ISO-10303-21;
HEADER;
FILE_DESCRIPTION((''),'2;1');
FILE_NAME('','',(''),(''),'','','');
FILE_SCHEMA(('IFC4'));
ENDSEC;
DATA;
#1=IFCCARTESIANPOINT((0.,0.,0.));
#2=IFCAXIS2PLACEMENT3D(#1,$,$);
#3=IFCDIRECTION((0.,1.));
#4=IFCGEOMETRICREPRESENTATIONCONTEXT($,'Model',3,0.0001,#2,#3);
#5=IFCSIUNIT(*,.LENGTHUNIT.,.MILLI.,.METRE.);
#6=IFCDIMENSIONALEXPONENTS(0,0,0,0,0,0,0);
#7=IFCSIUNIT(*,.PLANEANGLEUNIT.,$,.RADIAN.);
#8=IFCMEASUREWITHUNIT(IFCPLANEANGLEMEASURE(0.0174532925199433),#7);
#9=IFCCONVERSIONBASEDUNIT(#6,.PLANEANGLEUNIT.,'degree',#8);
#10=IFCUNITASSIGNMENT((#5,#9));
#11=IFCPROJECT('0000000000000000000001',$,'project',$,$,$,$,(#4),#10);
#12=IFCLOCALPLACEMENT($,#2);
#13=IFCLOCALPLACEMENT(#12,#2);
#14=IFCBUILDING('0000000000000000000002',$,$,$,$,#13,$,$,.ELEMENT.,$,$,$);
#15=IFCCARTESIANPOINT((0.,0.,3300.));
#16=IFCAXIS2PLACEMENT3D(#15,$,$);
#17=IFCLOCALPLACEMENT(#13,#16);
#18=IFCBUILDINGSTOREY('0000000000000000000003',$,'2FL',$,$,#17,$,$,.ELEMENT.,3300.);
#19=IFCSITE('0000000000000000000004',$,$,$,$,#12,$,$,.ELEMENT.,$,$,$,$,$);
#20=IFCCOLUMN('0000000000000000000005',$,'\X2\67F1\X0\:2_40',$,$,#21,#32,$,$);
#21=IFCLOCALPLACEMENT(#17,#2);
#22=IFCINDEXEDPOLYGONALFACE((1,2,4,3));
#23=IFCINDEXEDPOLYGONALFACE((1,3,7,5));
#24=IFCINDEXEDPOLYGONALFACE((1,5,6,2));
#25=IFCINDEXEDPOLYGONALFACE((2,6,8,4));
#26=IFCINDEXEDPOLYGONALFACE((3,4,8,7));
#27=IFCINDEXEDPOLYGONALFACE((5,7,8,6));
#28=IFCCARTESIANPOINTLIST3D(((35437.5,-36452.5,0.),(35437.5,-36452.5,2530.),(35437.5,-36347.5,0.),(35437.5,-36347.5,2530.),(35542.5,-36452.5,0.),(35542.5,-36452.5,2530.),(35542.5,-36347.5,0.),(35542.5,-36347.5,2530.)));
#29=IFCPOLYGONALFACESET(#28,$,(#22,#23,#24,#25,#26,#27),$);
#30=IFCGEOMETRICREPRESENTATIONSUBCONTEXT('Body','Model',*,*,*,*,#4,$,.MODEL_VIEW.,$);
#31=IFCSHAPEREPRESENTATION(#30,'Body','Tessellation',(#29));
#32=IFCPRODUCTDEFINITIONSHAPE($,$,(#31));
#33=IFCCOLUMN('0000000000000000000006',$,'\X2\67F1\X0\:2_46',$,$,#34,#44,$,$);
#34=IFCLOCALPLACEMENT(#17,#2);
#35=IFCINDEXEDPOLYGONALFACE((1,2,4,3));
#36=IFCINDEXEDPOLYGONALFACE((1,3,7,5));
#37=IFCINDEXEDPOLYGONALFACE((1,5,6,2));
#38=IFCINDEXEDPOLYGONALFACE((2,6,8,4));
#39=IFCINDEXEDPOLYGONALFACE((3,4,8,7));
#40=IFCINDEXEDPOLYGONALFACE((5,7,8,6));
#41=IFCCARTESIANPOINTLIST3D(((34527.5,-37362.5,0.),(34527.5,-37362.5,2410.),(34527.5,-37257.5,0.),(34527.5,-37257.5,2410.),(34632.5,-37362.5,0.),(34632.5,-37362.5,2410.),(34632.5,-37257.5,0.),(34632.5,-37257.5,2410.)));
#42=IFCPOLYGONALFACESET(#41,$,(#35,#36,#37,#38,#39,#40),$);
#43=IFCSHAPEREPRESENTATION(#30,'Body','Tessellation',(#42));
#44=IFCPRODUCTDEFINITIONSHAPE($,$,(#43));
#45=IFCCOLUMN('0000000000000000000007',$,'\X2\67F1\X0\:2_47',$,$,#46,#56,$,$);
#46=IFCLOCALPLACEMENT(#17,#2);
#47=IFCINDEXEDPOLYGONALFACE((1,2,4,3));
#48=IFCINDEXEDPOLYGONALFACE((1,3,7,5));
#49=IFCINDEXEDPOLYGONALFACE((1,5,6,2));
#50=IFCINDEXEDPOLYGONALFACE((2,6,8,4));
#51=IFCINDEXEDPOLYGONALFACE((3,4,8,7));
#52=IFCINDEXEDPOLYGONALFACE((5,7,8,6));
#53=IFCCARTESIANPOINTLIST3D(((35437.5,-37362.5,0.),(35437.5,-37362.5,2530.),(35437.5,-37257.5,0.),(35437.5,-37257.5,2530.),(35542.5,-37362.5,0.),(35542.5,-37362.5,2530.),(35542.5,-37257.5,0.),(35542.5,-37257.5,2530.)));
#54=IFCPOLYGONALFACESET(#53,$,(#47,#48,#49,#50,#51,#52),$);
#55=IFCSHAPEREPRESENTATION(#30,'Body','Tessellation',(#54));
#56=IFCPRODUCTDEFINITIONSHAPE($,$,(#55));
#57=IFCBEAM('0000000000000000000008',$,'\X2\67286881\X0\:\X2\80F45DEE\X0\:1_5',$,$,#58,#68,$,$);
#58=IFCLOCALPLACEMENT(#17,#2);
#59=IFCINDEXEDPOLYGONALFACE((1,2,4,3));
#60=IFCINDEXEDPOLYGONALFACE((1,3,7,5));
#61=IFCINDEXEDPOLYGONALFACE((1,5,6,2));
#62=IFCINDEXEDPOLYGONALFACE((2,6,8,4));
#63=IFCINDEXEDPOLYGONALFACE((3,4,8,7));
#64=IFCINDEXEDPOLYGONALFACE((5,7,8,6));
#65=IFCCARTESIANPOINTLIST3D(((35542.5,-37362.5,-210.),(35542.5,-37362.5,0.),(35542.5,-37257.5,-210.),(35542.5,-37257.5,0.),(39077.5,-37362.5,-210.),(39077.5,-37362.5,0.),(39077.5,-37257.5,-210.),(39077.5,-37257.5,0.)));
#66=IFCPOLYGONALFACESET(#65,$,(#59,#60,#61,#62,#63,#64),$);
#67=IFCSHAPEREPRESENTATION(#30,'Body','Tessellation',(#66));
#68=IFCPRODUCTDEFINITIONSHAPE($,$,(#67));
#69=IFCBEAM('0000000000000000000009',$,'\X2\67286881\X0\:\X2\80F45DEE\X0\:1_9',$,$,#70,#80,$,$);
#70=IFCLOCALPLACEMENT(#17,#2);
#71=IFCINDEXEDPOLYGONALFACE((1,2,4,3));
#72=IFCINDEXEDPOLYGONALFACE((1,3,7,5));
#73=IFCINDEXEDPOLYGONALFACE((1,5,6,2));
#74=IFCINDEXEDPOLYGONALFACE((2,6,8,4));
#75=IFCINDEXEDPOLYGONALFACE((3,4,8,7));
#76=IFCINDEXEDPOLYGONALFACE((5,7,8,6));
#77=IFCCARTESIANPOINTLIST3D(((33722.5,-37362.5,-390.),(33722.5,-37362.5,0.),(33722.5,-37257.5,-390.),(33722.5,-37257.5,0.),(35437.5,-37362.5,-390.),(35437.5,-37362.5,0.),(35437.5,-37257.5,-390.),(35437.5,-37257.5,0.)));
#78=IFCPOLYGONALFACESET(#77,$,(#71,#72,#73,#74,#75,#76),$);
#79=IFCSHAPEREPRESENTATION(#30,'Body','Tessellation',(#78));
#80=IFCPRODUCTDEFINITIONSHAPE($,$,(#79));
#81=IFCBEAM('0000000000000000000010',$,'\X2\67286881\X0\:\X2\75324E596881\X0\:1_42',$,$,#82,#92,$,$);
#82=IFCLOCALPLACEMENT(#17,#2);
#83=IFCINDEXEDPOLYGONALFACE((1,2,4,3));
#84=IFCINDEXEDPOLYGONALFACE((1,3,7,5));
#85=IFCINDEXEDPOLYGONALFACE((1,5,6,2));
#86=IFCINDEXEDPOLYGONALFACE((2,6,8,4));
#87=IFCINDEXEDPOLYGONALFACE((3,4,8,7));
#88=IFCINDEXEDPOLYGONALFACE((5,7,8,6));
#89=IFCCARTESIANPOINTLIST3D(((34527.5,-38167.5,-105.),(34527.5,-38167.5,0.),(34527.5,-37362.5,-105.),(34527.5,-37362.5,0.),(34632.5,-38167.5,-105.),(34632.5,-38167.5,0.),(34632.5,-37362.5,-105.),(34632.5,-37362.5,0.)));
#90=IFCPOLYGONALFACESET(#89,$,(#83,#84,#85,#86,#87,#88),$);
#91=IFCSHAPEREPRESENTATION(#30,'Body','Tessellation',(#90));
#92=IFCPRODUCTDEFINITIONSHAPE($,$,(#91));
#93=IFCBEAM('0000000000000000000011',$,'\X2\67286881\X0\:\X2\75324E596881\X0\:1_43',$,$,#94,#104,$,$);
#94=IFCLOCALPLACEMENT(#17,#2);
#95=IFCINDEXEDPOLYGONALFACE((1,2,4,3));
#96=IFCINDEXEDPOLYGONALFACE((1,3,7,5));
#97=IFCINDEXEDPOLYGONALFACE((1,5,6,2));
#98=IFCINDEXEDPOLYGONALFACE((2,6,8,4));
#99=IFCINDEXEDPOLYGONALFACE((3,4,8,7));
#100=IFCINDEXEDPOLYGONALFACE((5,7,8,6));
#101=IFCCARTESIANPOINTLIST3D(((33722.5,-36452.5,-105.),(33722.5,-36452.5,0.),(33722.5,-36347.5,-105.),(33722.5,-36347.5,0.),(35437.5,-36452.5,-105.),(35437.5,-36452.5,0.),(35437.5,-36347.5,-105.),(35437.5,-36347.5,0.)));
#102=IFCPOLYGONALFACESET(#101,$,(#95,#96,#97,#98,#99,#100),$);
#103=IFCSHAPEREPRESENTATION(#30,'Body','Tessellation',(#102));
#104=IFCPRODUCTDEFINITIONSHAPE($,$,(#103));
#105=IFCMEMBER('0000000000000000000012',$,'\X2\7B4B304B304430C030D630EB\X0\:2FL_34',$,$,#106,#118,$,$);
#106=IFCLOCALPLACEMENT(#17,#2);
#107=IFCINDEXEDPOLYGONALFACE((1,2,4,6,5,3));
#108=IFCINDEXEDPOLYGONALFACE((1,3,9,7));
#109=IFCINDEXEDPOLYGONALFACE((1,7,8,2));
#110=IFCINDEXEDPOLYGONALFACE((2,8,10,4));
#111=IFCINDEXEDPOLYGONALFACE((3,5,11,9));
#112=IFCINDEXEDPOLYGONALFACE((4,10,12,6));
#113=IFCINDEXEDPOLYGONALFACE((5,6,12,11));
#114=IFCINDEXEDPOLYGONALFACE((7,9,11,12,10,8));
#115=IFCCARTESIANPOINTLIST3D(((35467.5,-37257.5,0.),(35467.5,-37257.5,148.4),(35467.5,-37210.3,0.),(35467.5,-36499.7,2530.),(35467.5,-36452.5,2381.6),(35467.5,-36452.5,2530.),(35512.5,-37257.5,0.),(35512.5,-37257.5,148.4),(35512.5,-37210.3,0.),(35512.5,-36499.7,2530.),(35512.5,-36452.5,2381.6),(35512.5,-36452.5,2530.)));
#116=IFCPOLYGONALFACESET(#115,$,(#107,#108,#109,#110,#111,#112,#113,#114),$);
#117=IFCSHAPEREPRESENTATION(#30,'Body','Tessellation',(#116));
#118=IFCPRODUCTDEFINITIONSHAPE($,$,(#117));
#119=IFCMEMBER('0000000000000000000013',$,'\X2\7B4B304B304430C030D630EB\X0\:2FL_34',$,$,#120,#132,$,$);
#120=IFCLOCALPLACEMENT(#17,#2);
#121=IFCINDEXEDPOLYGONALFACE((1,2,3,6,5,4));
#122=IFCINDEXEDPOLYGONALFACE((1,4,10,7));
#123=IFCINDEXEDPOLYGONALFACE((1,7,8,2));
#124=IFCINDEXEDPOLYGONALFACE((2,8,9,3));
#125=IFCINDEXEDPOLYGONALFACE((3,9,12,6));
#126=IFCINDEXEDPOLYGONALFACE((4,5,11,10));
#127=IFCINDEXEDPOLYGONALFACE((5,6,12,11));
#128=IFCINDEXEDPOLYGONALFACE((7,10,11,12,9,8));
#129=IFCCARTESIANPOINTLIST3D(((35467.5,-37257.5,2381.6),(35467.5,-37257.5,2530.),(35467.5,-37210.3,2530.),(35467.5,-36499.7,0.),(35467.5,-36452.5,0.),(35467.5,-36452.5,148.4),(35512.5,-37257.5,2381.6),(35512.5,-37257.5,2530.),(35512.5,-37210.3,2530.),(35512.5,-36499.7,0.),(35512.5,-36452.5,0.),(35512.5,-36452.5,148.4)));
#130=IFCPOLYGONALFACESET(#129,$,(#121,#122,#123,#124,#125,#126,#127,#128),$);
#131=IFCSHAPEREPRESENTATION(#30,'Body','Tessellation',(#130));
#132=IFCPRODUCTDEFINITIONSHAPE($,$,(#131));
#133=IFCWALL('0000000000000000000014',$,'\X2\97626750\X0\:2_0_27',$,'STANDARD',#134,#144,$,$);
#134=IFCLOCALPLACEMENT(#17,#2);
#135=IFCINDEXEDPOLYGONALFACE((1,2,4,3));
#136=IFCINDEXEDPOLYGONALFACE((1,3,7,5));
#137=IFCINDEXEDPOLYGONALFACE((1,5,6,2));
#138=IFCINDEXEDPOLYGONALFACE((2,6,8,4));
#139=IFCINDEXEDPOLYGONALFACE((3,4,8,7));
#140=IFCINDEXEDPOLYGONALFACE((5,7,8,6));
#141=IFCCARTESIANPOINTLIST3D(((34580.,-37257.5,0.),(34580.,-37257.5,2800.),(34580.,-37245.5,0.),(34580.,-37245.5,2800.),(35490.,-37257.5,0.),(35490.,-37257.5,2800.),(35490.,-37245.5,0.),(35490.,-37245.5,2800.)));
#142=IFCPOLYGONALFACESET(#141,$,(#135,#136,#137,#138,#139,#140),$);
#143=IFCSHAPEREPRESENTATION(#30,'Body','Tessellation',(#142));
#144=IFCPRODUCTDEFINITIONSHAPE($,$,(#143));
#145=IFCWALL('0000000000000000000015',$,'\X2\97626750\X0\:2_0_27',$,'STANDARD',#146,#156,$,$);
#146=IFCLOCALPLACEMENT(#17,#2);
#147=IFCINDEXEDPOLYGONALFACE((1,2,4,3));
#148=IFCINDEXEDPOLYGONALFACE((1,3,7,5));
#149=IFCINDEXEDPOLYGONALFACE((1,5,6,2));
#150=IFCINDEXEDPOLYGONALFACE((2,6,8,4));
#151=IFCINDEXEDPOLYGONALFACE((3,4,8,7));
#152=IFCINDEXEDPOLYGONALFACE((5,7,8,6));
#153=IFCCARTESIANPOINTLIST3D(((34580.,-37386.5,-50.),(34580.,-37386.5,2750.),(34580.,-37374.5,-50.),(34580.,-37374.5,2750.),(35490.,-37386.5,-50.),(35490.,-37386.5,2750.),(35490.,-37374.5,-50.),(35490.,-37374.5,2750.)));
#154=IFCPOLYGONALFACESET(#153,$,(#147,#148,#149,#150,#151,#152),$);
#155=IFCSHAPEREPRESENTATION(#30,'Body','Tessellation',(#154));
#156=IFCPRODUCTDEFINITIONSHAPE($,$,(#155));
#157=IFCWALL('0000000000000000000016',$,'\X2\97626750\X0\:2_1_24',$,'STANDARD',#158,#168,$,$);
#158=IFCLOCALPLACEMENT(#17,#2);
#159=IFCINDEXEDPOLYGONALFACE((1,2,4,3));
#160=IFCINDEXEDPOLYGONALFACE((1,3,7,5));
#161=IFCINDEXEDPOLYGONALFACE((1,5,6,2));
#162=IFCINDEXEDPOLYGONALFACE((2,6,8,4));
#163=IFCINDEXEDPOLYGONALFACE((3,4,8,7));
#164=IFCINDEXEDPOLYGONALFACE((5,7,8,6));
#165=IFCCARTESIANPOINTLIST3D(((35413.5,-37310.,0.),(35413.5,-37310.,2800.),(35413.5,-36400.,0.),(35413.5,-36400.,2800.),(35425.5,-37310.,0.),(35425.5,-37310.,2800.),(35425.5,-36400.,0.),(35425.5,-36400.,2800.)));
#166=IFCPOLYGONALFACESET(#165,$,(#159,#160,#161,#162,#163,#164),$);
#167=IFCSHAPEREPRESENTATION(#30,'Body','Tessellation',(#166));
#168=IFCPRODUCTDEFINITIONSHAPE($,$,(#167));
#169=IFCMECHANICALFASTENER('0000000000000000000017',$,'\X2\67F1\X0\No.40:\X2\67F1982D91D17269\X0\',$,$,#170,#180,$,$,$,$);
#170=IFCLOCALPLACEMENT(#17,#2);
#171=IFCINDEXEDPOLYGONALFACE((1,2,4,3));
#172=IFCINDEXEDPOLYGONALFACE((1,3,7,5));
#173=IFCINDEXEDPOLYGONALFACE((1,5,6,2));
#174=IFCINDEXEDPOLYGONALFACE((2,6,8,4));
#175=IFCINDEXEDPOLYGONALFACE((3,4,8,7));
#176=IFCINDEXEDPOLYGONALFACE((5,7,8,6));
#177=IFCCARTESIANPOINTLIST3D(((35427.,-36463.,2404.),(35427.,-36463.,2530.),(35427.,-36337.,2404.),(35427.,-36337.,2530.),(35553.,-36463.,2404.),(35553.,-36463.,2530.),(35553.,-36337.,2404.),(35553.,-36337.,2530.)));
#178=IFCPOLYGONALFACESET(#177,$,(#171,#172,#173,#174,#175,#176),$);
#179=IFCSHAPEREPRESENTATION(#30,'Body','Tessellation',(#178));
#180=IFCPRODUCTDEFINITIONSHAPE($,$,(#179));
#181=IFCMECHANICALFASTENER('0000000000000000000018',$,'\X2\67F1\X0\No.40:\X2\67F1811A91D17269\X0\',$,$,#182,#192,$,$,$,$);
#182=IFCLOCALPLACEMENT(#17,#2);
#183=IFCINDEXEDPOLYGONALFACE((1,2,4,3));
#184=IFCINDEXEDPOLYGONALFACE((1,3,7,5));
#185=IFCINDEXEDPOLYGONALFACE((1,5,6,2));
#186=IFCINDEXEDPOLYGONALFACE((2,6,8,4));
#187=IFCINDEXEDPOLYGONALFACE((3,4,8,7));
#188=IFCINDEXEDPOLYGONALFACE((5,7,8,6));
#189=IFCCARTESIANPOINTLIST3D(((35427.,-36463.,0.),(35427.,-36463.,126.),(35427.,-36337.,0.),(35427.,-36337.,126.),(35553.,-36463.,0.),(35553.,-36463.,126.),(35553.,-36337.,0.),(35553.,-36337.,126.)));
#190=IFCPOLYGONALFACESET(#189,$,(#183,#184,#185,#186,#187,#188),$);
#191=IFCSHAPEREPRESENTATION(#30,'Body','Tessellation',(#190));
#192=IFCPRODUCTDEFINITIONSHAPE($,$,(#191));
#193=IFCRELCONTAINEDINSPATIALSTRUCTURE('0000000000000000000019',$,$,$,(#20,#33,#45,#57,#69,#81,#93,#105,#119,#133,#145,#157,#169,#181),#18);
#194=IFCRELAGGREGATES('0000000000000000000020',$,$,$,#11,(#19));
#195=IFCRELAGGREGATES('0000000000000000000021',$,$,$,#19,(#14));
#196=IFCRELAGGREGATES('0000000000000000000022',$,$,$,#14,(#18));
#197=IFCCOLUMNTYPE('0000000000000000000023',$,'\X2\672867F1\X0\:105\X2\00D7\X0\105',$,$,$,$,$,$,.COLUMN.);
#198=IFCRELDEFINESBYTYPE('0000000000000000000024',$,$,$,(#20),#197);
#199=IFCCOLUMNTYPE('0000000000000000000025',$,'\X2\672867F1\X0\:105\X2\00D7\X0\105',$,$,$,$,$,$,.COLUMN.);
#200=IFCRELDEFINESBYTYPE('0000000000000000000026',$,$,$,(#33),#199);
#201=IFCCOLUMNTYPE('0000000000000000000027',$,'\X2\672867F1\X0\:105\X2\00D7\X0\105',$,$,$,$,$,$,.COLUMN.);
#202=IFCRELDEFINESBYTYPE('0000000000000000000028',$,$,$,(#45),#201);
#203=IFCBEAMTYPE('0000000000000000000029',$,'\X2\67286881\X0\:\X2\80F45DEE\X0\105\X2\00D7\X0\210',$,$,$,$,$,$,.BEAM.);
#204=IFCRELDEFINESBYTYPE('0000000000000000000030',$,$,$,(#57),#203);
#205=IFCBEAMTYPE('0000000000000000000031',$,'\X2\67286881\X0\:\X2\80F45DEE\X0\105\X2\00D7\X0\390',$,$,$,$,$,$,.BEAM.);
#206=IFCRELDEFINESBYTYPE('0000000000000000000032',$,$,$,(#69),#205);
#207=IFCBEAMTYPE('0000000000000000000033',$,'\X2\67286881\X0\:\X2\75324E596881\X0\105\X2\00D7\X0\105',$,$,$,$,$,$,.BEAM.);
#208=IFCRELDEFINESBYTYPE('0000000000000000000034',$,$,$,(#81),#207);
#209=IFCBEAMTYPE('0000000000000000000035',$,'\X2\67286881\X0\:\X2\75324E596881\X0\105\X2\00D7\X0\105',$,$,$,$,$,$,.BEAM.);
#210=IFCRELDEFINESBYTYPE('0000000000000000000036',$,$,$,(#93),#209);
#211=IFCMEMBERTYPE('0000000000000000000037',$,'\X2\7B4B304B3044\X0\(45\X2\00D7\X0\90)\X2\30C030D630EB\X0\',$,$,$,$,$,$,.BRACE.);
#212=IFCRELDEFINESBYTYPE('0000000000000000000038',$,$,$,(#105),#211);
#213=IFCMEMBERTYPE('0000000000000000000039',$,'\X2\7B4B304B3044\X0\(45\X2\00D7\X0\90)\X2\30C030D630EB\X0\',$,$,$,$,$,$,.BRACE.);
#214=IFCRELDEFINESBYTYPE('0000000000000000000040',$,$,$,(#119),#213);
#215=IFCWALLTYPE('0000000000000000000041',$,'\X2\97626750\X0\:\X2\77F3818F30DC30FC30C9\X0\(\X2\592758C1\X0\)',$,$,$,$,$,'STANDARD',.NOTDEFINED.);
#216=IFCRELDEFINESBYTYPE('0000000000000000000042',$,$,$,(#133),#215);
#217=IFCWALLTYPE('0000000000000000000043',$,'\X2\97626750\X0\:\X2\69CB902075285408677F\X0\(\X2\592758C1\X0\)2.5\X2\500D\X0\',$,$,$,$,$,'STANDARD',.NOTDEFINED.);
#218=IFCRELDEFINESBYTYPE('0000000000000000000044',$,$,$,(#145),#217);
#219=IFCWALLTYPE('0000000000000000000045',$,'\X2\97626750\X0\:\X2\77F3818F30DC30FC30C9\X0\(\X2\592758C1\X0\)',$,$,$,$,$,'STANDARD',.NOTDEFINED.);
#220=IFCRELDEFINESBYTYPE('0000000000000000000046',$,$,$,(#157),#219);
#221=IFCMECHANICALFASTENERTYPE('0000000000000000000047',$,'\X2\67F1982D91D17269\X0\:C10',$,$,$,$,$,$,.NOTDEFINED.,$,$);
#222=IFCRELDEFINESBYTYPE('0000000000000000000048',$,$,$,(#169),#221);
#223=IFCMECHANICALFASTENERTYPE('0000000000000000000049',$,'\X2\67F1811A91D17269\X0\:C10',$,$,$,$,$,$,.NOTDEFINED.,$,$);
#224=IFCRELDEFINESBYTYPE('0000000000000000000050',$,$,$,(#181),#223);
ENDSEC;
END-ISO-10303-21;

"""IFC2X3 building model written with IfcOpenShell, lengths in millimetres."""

from ifc_helpers import new_model, entity, si_unit, converted_unit, direction, frame, origin, origin_with_axes, origin_2d, place, context, subcontext, project, spatial, polyline, rectangle, outline, extrude, type_object, element, save


model = new_model("IFC2X3")

# Units and contexts
model_context = context("Model", 3, precision=0.0001, world=origin(), true_north=direction((0.0, 1.0)))
body_context = subcontext(model_context, "Body", "Model", "MODEL_VIEW")
ifc_project = project(units=[si_unit("LENGTHUNIT", "METRE", prefix="MILLI"), converted_unit("PLANEANGLEUNIT", "degree", entity("IfcPlaneAngleMeasure", 0.0174532925199433), si_unit("PLANEANGLEUNIT", "RADIAN"), dimensions=[0, 0, 0, 0, 0, 0, 0])], contexts=[model_context])

# Site, building, storey
site_placement = place(None, origin())
site = spatial("IfcSite", under=ifc_project, at=site_placement, CompositionType="ELEMENT")
building_placement = place(site_placement, origin())
building = spatial("IfcBuilding", under=site, at=building_placement, CompositionType="ELEMENT")
storey_placement = place(building_placement, frame((0.0, 0.0, 3300.0)))
storey = spatial("IfcBuildingStorey", under=building, at=storey_placement, Name="2FL", CompositionType="ELEMENT", Elevation=3300.0)

# Columns
column_type_1 = type_object("IfcColumnType", Name="木柱:105×105", PredefinedType="COLUMN")
column_1_placement = place(storey_placement, frame((35490.0, -36400.0, 0.0)))
element("IfcColumn", 1, at=column_1_placement, inside=storey, type_object=column_type_1, Name="柱:2_40", context=body_context, shape_type="SweptSolid", body=[
    extrude(rectangle(XDim=105.0, YDim=105.0, at=origin_2d()), origin_with_axes(), (0.0, 0.0, 1.0), 2530.0),
])
column_type_2 = type_object("IfcColumnType", Name="木柱:105×105", PredefinedType="COLUMN")
column_2_placement = place(storey_placement, frame((34580.0, -37310.0, 0.0)))
element("IfcColumn", 2, at=column_2_placement, inside=storey, type_object=column_type_2, Name="柱:2_46", context=body_context, shape_type="SweptSolid", body=[
    extrude(rectangle(XDim=105.0, YDim=105.0, at=origin_2d()), origin_with_axes(), (0.0, 0.0, 1.0), 2410.0),
])
column_type_3 = type_object("IfcColumnType", Name="木柱:105×105", PredefinedType="COLUMN")
column_3_placement = place(storey_placement, frame((35490.0, -37310.0, 0.0)))
element("IfcColumn", 3, at=column_3_placement, inside=storey, type_object=column_type_3, Name="柱:2_47", context=body_context, shape_type="SweptSolid", body=[
    extrude(rectangle(XDim=105.0, YDim=105.0, at=origin_2d()), origin_with_axes(), (0.0, 0.0, 1.0), 2530.0),
])

# Beams
beam_type_1 = type_object("IfcBeamType", Name="木梁:胴差105×210", PredefinedType="BEAM")
beam_1_placement = place(storey_placement, frame((35542.5, -37310.0, -105.0), z_axis=(1.0, 0.0, 0.0), x_axis=(0.0, 1.0, 0.0)))
element("IfcBeam", 4, at=beam_1_placement, inside=storey, type_object=beam_type_1, Name="木梁:胴差:1_5", context=body_context, shape_type="SweptSolid", body=[
    extrude(rectangle(XDim=105.0, YDim=210.0, at=origin_2d()), origin_with_axes(), (0.0, 0.0, 1.0), 3535.0),
])
beam_type_2 = type_object("IfcBeamType", Name="木梁:胴差105×390", PredefinedType="BEAM")
beam_2_placement = place(storey_placement, frame((33722.5, -37310.0, -195.0), z_axis=(1.0, 0.0, 0.0), x_axis=(0.0, 1.0, 0.0)))
element("IfcBeam", 5, at=beam_2_placement, inside=storey, type_object=beam_type_2, Name="木梁:胴差:1_9", context=body_context, shape_type="SweptSolid", body=[
    extrude(rectangle(XDim=105.0, YDim=390.0, at=origin_2d()), origin_with_axes(), (0.0, 0.0, 1.0), 1715.0),
])
beam_type_3 = type_object("IfcBeamType", Name="木梁:甲乙梁105×105", PredefinedType="BEAM")
beam_3_placement = place(storey_placement, frame((34580.0, -37362.5, -52.5), z_axis=(0.0, -1.0, 0.0), x_axis=(1.0, 0.0, 0.0)))
element("IfcBeam", 6, at=beam_3_placement, inside=storey, type_object=beam_type_3, Name="木梁:甲乙梁:1_42", context=body_context, shape_type="SweptSolid", body=[
    extrude(rectangle(XDim=105.0, YDim=105.0, at=origin_2d()), origin_with_axes(), (0.0, 0.0, 1.0), 805.0),
])
beam_type_4 = type_object("IfcBeamType", Name="木梁:甲乙梁105×105", PredefinedType="BEAM")
beam_4_placement = place(storey_placement, frame((33722.5, -36400.0, -52.5), z_axis=(1.0, 0.0, 0.0), x_axis=(0.0, 1.0, 0.0)))
element("IfcBeam", 7, at=beam_4_placement, inside=storey, type_object=beam_type_4, Name="木梁:甲乙梁:1_43", context=body_context, shape_type="SweptSolid", body=[
    extrude(rectangle(XDim=105.0, YDim=105.0, at=origin_2d()), origin_with_axes(), (0.0, 0.0, 1.0), 1715.0),
])

# Members
member_type_1 = type_object("IfcMemberType", Name="筋かい(45×90)ダブル", PredefinedType="BRACE")
member_1_placement = place(storey_placement, frame((35490.0, -37257.5, 0.0), z_axis=(0.0, 0.303204, 0.952926), x_axis=(0.0, -0.952926, 0.303204)))
element("IfcMember", 8, at=member_1_placement, inside=storey, type_object=member_type_1, Name="筋かいダブル:2FL_34", context=body_context, shape_type="SweptSolid", body=[
    extrude(outline(polyline([(0.0, 0.0), (14.3, -45.0), (2513.6, -45.0), (2655.0, 0.0), (2640.7, 45.0), (141.4, 45.0), (0.0, 0.0)])), frame((0.0, -22.5, 0.0), z_axis=(0.0, 1.0, 0.0), x_axis=(0.0, 0.0, 1.0)), (0.0, 0.0, 1.0), 45.0),
])
member_type_2 = type_object("IfcMemberType", Name="筋かい(45×90)ダブル", PredefinedType="BRACE")
member_2_placement = place(storey_placement, frame((35490.0, -36452.5, 0.0), z_axis=(0.0, -0.303204, 0.952926), x_axis=(0.0, 0.952926, 0.303204)))
element("IfcMember", 9, at=member_2_placement, inside=storey, type_object=member_type_2, Name="筋かいダブル:2FL_34", context=body_context, shape_type="SweptSolid", body=[
    extrude(outline(polyline([(0.0, 0.0), (14.3, -45.0), (2513.6, -45.0), (2655.0, 0.0), (2640.7, 45.0), (141.4, 45.0), (0.0, 0.0)])), frame((0.0, -22.5, 0.0), z_axis=(0.0, 1.0, 0.0), x_axis=(0.0, 0.0, 1.0)), (0.0, 0.0, 1.0), 45.0),
])

# Walls
wall_type_1 = type_object("IfcWallType", Name="面材:石膏ボード(大壁)", ElementType="STANDARD", PredefinedType="NOTDEFINED")
wall_1_placement = place(storey_placement, frame((35035.0, -37245.5, 0.0), z_axis=(0.0, -1.0, 0.0), x_axis=(1.0, 0.0, 0.0)))
element("IfcWall", 10, at=wall_1_placement, inside=storey, type_object=wall_type_1, Name="面材:2_0_27", ObjectType="STANDARD", context=body_context, shape_type="SweptSolid", body=[
    extrude(outline(polyline([(455.0, 0.0, 0.0), (-455.0, 0.0, 0.0), (-455.0, 2800.0, 0.0), (455.0, 2800.0, 0.0), (455.0, 0.0, 0.0)])), origin_with_axes(), (0.0, 0.0, 1.0), 12.0),
])
wall_type_2 = type_object("IfcWallType", Name="面材:構造用合板(大壁)2.5倍", ElementType="STANDARD", PredefinedType="NOTDEFINED")
wall_2_placement = place(storey_placement, frame((35035.0, -37374.5, -50.0), z_axis=(0.0, -1.0, 0.0), x_axis=(1.0, 0.0, 0.0)))
element("IfcWall", 11, at=wall_2_placement, inside=storey, type_object=wall_type_2, Name="面材:2_0_27", ObjectType="STANDARD", context=body_context, shape_type="SweptSolid", body=[
    extrude(outline(polyline([(455.0, 0.0, 0.0), (-455.0, 0.0, 0.0), (-455.0, 2800.0, 0.0), (455.0, 2800.0, 0.0), (455.0, 0.0, 0.0)])), origin_with_axes(), (0.0, 0.0, 1.0), 12.0),
])
wall_type_3 = type_object("IfcWallType", Name="面材:石膏ボード(大壁)", ElementType="STANDARD", PredefinedType="NOTDEFINED")
wall_3_placement = place(storey_placement, frame((35425.5, -36855.0, 0.0), z_axis=(-1.0, 0.0, 0.0), x_axis=(0.0, -1.0, 0.0)))
element("IfcWall", 12, at=wall_3_placement, inside=storey, type_object=wall_type_3, Name="面材:2_1_24", ObjectType="STANDARD", context=body_context, shape_type="SweptSolid", body=[
    extrude(outline(polyline([(455.0, 0.0, 0.0), (-455.0, 0.0, 0.0), (-455.0, 2800.0, 0.0), (455.0, 2800.0, 0.0), (455.0, 0.0, 0.0)])), origin_with_axes(), (0.0, 0.0, 1.0), 12.0),
])

# Mechanical fasteners
mechanical_fastener_type_1 = type_object("IfcMechanicalFastenerType", Name="柱頭金物:C10")
mechanical_fastener_1_placement = place(storey_placement, frame((35490.0, -36400.0, 2404.0)))
element("IfcMechanicalFastener", 13, at=mechanical_fastener_1_placement, inside=storey, type_object=mechanical_fastener_type_1, Name="柱No.40:柱頭金物", context=body_context, shape_type="SweptSolid", body=[
    extrude(rectangle(XDim=126.0, YDim=126.0, at=origin_2d()), origin_with_axes(), (0.0, 0.0, 1.0), 126.0),
])
mechanical_fastener_type_2 = type_object("IfcMechanicalFastenerType", Name="柱脚金物:C10")
mechanical_fastener_2_placement = place(storey_placement, frame((35490.0, -36400.0, 0.0)))
element("IfcMechanicalFastener", 14, at=mechanical_fastener_2_placement, inside=storey, type_object=mechanical_fastener_type_2, Name="柱No.40:柱脚金物", context=body_context, shape_type="SweptSolid", body=[
    extrude(rectangle(XDim=126.0, YDim=126.0, at=origin_2d()), origin_with_axes(), (0.0, 0.0, 1.0), 126.0),
])

save(model, "model.ifc")
